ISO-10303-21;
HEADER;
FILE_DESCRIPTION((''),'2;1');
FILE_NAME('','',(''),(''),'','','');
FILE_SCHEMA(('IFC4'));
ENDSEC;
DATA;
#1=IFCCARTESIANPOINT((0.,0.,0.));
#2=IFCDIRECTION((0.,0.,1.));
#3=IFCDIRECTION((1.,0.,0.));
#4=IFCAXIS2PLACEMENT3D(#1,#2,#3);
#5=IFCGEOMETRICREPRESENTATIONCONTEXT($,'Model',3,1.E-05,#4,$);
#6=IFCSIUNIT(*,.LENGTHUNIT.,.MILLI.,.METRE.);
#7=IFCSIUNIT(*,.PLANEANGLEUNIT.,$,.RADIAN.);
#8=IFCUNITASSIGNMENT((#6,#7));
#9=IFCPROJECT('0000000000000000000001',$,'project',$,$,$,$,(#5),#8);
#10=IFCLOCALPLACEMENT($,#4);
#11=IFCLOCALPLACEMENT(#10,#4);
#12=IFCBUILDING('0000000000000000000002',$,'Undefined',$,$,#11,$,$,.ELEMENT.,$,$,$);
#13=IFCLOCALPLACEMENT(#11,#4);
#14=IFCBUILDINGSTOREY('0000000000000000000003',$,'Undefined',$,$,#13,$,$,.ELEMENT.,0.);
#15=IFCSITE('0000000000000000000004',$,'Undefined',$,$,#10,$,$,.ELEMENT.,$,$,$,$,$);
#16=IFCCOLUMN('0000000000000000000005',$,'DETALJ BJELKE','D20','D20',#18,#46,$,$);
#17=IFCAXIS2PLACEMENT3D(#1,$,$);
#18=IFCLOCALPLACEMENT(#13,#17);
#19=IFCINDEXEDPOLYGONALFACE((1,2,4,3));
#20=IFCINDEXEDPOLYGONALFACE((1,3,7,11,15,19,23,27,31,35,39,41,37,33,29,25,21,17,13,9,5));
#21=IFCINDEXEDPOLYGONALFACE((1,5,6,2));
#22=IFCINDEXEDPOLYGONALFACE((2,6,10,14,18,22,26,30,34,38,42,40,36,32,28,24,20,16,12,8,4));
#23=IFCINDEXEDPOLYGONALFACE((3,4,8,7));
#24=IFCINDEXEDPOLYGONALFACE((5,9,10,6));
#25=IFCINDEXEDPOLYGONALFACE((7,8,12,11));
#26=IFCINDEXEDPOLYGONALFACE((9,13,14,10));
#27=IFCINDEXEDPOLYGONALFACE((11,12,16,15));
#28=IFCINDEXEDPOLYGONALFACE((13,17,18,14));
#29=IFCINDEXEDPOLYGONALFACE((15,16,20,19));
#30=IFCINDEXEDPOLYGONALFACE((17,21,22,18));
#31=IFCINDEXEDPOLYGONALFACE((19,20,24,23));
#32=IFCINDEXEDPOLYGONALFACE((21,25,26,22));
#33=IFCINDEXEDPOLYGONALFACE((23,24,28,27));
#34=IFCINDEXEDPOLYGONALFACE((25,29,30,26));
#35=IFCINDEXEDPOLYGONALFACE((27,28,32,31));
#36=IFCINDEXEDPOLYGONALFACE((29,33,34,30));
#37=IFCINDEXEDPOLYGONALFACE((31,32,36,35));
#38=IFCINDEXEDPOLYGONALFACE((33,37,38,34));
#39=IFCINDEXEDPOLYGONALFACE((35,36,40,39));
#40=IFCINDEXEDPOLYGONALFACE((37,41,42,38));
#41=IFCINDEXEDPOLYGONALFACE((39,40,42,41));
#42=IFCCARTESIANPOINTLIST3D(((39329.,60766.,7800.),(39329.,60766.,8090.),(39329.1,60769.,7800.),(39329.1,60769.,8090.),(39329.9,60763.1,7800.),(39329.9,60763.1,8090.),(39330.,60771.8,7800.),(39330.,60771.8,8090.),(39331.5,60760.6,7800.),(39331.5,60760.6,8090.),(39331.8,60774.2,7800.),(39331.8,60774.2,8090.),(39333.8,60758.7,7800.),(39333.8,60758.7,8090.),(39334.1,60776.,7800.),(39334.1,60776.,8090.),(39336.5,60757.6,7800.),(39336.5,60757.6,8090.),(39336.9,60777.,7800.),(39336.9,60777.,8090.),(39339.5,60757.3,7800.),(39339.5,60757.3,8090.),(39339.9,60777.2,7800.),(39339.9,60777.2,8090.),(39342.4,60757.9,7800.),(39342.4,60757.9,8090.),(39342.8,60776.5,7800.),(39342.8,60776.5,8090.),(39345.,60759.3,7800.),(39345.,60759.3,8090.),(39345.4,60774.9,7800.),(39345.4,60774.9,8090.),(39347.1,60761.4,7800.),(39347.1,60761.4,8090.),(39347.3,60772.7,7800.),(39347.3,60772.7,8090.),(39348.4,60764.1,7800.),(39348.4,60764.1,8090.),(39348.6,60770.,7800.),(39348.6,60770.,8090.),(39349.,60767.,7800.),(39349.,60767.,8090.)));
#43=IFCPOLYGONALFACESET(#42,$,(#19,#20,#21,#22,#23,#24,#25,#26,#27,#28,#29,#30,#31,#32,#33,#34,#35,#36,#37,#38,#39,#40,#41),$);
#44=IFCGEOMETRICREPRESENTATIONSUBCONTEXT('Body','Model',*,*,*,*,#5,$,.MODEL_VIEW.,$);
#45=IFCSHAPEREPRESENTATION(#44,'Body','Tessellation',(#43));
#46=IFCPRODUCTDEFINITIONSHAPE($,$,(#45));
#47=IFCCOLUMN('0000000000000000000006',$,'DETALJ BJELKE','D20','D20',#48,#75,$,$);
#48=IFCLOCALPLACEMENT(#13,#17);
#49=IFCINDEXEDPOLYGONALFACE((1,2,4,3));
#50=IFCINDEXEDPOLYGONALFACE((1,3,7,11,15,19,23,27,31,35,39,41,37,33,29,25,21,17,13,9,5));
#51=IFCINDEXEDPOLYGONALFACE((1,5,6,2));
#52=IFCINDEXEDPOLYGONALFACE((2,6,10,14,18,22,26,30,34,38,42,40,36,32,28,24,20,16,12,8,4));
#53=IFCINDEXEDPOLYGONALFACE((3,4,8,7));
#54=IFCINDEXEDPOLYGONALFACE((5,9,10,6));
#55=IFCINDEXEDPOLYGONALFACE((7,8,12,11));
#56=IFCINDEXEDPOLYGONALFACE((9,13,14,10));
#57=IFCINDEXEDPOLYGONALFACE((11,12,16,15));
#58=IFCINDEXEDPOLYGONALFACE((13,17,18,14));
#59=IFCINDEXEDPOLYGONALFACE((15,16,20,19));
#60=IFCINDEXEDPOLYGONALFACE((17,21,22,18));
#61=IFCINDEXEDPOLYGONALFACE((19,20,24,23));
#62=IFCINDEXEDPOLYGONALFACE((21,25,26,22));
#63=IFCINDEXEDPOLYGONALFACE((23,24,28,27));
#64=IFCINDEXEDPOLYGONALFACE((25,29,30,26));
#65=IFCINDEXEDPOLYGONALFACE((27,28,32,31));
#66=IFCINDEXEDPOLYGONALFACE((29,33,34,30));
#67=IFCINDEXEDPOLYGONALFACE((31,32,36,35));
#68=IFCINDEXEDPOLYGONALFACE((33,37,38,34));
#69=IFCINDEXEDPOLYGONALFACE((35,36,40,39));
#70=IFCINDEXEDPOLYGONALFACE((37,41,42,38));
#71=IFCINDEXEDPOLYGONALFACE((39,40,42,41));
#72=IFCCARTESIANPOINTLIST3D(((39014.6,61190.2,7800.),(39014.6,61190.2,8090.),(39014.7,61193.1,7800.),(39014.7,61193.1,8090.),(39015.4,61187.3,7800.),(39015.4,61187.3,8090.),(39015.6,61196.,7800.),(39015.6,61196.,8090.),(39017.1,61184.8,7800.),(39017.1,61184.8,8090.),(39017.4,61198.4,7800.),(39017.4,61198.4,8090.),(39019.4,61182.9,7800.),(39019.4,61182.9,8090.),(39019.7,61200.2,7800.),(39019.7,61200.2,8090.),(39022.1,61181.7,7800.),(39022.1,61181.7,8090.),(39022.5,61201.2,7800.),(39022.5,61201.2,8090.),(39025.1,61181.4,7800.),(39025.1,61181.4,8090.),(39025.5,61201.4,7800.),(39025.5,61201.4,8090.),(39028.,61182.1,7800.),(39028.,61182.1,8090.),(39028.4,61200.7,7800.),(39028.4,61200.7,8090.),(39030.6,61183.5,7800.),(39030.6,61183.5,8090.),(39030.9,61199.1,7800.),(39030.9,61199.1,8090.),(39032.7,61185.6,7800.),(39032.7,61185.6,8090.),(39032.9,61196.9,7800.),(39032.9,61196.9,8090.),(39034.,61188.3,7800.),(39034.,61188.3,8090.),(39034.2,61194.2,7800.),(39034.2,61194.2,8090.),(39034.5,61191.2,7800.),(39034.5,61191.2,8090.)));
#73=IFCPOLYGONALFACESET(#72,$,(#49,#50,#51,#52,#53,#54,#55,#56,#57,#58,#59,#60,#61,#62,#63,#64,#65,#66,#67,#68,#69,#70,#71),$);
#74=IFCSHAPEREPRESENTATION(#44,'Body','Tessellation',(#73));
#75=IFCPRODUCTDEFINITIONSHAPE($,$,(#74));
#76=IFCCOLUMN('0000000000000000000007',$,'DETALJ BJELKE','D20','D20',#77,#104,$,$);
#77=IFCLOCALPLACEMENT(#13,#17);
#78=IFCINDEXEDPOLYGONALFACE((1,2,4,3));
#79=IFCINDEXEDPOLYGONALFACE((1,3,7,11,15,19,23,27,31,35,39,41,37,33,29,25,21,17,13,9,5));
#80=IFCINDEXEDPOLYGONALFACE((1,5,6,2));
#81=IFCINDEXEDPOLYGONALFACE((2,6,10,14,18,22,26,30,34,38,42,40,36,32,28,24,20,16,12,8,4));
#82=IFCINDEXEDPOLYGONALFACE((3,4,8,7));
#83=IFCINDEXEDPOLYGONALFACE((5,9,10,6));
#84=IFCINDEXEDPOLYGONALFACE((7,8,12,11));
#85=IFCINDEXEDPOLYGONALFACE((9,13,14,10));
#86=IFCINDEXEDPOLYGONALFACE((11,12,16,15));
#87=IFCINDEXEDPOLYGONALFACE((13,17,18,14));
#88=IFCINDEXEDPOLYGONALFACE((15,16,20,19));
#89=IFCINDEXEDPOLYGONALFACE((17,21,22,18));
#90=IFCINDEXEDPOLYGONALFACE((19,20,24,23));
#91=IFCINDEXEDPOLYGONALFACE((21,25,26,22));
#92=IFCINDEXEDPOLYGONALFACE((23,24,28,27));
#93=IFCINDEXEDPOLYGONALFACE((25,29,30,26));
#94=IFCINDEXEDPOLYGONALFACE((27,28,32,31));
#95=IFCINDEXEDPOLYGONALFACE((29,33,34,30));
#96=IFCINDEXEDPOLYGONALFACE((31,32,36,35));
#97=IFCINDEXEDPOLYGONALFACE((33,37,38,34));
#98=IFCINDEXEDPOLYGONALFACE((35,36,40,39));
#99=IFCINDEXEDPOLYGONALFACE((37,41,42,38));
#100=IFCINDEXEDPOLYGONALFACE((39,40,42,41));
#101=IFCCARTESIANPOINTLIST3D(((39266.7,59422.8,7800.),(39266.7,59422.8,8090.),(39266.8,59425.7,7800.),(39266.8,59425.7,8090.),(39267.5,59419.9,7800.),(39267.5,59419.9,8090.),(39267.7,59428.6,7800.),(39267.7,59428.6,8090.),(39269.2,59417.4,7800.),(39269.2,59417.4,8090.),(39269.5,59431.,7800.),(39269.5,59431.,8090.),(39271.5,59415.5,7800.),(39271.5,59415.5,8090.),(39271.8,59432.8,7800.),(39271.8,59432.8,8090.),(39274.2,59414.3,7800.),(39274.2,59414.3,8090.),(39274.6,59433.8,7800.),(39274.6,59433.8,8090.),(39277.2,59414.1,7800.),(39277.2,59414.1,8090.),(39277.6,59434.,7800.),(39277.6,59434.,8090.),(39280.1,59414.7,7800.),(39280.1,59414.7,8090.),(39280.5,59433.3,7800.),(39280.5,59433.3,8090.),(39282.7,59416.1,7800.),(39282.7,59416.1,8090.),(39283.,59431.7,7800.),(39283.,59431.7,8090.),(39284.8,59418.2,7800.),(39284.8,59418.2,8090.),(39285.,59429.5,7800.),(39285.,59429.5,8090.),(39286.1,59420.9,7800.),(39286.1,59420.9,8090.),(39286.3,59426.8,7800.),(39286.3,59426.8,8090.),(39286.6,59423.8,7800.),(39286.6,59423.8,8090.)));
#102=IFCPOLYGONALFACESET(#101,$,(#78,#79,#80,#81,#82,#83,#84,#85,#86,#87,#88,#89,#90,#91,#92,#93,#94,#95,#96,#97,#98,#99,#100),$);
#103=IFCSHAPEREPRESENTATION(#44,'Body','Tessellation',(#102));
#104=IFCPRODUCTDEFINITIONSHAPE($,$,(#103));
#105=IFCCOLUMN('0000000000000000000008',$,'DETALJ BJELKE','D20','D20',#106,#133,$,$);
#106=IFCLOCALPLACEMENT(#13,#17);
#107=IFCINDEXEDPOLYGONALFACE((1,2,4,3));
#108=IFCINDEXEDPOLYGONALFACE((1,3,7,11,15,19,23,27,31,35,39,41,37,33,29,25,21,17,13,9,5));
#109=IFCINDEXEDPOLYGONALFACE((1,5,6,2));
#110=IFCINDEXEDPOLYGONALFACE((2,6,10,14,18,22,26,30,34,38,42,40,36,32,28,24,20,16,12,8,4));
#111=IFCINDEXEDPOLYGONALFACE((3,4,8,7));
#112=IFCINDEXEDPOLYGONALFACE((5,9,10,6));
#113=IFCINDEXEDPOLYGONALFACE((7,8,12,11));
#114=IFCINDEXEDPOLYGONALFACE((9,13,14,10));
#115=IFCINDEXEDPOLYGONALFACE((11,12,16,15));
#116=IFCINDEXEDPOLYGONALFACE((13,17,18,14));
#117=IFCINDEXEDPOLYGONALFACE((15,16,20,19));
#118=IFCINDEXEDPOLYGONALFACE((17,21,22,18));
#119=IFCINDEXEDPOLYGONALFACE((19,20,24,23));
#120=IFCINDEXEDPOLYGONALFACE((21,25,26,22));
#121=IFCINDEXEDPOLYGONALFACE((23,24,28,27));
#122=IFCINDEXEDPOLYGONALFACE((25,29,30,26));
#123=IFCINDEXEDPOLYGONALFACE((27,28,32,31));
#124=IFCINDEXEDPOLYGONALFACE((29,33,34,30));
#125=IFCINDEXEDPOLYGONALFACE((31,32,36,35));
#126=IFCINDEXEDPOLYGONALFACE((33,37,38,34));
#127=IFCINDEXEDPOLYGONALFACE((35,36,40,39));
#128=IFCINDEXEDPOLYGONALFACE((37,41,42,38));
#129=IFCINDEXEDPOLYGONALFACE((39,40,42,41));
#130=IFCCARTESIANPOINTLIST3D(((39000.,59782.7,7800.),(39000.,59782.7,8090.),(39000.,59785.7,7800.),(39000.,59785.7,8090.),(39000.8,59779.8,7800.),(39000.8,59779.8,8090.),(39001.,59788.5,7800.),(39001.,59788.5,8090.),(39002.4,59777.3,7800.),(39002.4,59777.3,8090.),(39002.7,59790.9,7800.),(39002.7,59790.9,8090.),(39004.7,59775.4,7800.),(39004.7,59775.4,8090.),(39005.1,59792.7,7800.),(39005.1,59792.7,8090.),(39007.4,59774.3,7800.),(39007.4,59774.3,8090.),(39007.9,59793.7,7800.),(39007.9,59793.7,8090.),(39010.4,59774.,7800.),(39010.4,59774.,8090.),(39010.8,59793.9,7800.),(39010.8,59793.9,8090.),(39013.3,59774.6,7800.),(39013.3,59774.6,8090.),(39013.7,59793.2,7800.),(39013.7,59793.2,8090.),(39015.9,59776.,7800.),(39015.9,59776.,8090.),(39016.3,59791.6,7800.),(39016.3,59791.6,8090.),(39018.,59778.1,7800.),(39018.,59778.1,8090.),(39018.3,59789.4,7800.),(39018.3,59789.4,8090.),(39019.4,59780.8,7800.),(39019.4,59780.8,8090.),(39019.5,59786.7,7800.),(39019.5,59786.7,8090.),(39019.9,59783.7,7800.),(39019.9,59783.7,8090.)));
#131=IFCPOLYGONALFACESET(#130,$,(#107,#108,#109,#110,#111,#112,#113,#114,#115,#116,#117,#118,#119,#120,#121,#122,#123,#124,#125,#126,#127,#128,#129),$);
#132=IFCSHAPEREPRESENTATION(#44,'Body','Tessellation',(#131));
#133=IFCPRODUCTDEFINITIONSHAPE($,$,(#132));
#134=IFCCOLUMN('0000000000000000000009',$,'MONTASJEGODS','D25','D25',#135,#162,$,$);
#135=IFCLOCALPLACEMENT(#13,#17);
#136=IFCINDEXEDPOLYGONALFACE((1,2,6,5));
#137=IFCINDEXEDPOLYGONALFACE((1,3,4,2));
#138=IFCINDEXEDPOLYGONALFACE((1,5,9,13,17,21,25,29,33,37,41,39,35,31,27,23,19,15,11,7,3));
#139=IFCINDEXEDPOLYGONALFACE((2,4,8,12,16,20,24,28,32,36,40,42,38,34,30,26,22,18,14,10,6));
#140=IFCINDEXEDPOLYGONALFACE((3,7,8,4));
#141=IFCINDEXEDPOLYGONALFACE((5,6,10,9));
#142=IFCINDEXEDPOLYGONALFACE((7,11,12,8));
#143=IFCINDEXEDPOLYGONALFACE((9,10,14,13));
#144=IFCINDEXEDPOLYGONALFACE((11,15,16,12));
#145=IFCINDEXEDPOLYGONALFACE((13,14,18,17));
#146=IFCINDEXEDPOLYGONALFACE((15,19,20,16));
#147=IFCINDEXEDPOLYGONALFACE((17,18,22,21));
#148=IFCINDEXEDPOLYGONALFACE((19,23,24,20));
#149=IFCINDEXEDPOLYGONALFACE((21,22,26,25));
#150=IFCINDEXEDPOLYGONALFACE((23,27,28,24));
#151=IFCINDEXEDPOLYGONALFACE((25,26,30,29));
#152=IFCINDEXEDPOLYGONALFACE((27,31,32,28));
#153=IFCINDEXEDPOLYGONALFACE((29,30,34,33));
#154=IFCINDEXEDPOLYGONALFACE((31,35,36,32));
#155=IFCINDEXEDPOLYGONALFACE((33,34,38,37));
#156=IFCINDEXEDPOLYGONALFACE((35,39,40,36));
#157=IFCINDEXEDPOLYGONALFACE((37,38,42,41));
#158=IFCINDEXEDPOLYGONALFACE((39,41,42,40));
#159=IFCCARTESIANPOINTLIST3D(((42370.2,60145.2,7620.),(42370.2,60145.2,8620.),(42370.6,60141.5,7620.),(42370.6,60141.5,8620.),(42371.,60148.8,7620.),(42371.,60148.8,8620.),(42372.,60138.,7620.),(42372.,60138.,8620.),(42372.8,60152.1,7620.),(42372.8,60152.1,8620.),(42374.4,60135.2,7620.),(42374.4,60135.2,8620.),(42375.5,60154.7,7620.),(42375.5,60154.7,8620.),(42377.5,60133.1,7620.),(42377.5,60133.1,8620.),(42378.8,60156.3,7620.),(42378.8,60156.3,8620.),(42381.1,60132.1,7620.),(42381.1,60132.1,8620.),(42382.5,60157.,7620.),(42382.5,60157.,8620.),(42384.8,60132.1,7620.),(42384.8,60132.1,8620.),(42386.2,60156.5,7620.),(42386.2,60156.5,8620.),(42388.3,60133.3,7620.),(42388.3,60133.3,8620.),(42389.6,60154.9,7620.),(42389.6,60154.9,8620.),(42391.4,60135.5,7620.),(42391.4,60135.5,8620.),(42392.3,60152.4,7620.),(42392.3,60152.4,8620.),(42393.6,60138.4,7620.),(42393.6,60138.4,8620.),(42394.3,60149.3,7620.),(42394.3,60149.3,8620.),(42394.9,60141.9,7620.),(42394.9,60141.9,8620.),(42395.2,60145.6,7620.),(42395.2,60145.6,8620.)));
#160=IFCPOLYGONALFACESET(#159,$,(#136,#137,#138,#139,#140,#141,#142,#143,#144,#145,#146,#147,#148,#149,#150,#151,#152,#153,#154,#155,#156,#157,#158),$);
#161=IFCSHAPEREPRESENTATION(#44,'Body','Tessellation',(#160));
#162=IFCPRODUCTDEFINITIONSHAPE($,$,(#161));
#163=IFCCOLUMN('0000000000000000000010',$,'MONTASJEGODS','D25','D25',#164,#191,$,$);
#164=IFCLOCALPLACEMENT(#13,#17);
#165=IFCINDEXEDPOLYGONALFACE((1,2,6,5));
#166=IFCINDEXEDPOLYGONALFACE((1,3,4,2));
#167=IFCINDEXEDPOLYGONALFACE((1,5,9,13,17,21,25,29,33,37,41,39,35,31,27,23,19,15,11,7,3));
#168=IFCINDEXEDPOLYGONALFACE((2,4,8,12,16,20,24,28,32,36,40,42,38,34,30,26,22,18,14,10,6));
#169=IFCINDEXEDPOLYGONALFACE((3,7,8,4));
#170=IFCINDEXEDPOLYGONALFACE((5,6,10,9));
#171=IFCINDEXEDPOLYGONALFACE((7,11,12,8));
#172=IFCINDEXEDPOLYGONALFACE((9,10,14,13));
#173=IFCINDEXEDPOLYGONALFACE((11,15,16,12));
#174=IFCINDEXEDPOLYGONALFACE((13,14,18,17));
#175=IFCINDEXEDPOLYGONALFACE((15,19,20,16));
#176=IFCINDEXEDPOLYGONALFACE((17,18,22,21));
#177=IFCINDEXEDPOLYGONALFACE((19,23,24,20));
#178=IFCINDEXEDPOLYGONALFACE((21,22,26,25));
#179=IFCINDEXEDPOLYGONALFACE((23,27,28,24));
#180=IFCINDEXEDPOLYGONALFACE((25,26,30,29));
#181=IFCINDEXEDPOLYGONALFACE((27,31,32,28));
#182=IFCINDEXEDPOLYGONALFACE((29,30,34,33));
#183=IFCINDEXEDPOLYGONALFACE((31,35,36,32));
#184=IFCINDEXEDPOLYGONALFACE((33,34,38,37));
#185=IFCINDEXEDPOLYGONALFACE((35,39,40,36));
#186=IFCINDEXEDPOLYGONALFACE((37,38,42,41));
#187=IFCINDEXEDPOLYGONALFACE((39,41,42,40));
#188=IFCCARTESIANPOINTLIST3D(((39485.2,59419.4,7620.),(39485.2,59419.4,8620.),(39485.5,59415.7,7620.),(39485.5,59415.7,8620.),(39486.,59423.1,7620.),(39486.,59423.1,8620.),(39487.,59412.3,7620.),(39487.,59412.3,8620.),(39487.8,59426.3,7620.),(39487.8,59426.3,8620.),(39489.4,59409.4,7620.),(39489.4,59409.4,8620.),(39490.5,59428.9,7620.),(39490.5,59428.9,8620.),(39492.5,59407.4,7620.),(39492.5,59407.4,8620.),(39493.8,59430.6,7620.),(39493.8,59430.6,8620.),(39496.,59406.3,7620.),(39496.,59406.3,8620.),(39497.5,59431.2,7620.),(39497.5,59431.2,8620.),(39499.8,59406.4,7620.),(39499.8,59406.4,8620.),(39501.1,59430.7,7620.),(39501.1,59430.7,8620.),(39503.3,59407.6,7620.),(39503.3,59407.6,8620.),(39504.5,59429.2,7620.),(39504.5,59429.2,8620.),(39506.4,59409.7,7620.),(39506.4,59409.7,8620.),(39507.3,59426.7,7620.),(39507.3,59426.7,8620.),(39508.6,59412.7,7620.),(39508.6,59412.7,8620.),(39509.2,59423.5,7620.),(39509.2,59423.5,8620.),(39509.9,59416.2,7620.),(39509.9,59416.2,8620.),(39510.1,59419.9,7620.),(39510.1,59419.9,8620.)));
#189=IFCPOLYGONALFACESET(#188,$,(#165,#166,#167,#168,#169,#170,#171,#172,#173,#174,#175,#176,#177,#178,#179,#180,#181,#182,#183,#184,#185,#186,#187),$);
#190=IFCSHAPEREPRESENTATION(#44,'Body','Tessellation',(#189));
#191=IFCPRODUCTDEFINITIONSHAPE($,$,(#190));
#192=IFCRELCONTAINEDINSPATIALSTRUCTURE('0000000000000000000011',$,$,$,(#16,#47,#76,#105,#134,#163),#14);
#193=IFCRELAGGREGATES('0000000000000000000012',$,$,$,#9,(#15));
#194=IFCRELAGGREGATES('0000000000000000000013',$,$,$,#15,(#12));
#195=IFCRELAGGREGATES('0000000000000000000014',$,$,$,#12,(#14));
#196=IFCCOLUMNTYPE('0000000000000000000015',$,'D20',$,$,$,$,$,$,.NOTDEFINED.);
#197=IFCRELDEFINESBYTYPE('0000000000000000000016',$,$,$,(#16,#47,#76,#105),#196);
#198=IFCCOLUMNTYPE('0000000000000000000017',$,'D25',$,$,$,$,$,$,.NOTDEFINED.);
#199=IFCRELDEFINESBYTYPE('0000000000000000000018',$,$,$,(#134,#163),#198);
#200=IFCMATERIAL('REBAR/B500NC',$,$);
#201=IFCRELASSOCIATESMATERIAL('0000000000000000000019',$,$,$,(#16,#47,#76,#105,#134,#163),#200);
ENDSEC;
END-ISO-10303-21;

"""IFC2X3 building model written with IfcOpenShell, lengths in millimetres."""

from ifc_helpers import new_model, si_unit, frame, origin_with_axes, origin_2d_with_axis, place, context, subcontext, project, spatial, circle, extrude, material, type_object, element, save


model = new_model("IFC2X3")

# Units and contexts
model_context = context("Model", 3, precision=1e-05, world=origin_with_axes())
body_context = subcontext(model_context, "Body", "Model", "MODEL_VIEW")
ifc_project = project(units=[si_unit("LENGTHUNIT", "METRE", prefix="MILLI"), si_unit("PLANEANGLEUNIT", "RADIAN")], contexts=[model_context])

# Site, building, storey
site_placement = place(None, origin_with_axes())
site = spatial("IfcSite", under=ifc_project, at=site_placement, Name="Undefined", CompositionType="ELEMENT")
building_placement = place(site_placement, origin_with_axes())
building = spatial("IfcBuilding", under=site, at=building_placement, Name="Undefined", CompositionType="ELEMENT")
storey_placement = place(building_placement, origin_with_axes())
storey = spatial("IfcBuildingStorey", under=building, at=storey_placement, Name="Undefined", CompositionType="ELEMENT", Elevation=0.0)

# Columns
ifc_material_1 = material(Name="REBAR/B500NC")
column_type_1 = type_object("IfcColumnType", Name="D20", PredefinedType="NOTDEFINED")
for number, where, z_axis, x_axis, name in (
    (1, (39339.0, 60767.3, 7800.0), (0.0, 0.0, 1.0), (-0.794879, -0.606769, 0.0), "DETALJ BJELKE"),
    (2, (39024.5, 61191.4, 7800.0), (0.0, 0.0, 1.0), (-0.794879, -0.606769, 0.0), "DETALJ BJELKE"),
    (3, (39276.6, 59424.0, 7800.0), (0.0, 0.0, 1.0), (-0.794879, -0.606769, 0.0), "DETALJ BJELKE"),
    (4, (39009.9, 59784.0, 7800.0), (0.0, 0.0, 1.0), (-0.794879, -0.606769, 0.0), "DETALJ BJELKE"),
):
    element("IfcColumn", number, at=place(storey_placement, frame(where, z_axis=z_axis, x_axis=x_axis)), inside=storey, type_object=column_type_1, material=ifc_material_1, Name=name, Description="D20", ObjectType="D20", context=body_context, shape_type="SweptSolid", body=[
        extrude(circle(Radius=10.0, at=origin_2d_with_axis()), frame((0.0, 0.0, 290.0), z_axis=(0.0, 0.0, -1.0), x_axis=(0.0, 1.0, 0.0)), (0.0, 0.0, 1.0), 290.0),
    ])
column_type_2 = type_object("IfcColumnType", Name="D25", PredefinedType="NOTDEFINED")
for number, where, z_axis, x_axis, name in (
    (5, (42382.7, 60144.5, 7620.0), (0.0, 0.0, 1.0), (-0.892819, -0.450415, 0.0), "MONTASJEGODS"),
    (6, (39497.7, 59418.7, 7620.0), (0.0, 0.0, 1.0), (-0.892819, -0.450415, 0.0), "MONTASJEGODS"),
):
    element("IfcColumn", number, at=place(storey_placement, frame(where, z_axis=z_axis, x_axis=x_axis)), inside=storey, type_object=column_type_2, material=ifc_material_1, Name=name, Description="D25", ObjectType="D25", context=body_context, shape_type="SweptSolid", body=[
        extrude(circle(Radius=12.5, at=origin_2d_with_axis()), frame((0.0, 0.0, 1000.0), z_axis=(0.0, 0.0, -1.0), x_axis=(0.0, 1.0, 0.0)), (0.0, 0.0, 1.0), 1000.0),
    ])

save(model, "model.ifc")
